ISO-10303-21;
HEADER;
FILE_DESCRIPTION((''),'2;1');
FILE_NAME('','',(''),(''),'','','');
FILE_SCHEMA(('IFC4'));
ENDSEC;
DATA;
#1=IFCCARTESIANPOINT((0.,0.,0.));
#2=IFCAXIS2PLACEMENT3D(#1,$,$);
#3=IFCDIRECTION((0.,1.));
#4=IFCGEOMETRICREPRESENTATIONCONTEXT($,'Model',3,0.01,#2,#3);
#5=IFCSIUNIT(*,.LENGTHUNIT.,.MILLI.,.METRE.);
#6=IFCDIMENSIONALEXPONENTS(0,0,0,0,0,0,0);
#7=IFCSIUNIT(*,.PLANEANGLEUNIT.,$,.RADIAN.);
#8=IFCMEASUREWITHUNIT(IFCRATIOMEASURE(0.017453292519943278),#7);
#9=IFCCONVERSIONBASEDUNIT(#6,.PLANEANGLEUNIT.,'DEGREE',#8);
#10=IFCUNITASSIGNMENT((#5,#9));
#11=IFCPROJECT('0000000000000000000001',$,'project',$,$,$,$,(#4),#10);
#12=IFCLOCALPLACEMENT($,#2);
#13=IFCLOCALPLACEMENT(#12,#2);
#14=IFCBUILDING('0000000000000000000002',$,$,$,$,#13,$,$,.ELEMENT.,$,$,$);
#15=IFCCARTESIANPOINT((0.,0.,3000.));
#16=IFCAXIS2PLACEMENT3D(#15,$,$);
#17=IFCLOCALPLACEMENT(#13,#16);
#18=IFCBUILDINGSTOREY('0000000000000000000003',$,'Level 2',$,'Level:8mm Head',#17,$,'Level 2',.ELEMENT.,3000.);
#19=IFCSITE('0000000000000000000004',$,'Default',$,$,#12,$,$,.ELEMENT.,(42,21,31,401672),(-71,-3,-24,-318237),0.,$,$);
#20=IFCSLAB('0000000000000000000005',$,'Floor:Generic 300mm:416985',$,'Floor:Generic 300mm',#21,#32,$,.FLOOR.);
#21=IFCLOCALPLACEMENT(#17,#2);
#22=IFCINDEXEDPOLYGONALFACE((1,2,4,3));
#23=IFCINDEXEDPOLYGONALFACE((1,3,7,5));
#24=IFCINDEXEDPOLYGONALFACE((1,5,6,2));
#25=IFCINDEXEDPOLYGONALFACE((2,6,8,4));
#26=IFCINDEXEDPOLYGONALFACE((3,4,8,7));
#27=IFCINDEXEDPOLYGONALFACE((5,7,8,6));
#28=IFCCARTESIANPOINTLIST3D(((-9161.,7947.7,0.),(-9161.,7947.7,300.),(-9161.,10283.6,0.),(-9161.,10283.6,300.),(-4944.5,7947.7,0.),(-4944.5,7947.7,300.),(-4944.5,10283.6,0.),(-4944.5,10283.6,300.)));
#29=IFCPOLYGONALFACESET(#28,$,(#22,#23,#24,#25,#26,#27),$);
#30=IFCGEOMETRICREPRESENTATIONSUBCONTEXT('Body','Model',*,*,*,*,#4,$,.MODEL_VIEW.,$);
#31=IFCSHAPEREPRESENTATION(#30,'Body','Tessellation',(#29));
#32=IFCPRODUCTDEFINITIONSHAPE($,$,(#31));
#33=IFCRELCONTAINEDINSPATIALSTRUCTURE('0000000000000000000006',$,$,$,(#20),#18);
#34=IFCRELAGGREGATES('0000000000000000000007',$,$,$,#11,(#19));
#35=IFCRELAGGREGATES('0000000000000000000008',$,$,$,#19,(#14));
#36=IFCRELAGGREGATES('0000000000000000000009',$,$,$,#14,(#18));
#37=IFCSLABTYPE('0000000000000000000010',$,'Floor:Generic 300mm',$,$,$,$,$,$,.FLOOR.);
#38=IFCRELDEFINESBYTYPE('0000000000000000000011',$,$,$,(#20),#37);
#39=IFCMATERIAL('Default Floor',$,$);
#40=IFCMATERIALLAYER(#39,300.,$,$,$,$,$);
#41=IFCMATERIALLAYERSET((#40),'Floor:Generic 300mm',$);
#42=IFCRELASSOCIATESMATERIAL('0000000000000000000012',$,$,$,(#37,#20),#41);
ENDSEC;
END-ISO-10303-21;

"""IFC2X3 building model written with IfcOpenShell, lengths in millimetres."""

from ifc_helpers import new_model, entity, si_unit, converted_unit, direction, frame, origin, origin_2d_with_axis, place, context, subcontext, project, spatial, rectangle, extrude, material, layer, layer_set, layer_usage, type_object, element, save


model = new_model("IFC2X3")

# Units and contexts
model_context = context("Model", 3, precision=0.01, world=origin(), true_north=direction((0.0, 1.0)))
body_context = subcontext(model_context, "Body", "Model", "MODEL_VIEW")
ifc_project = project(units=[si_unit("LENGTHUNIT", "METRE", prefix="MILLI"), converted_unit("PLANEANGLEUNIT", "DEGREE", entity("IfcRatioMeasure", 0.017453292519943278), si_unit("PLANEANGLEUNIT", "RADIAN"), dimensions=[0, 0, 0, 0, 0, 0, 0])], contexts=[model_context])

# Site, building, storey
site_placement = place(None, origin())
site = spatial("IfcSite", under=ifc_project, at=site_placement, Name="Default", CompositionType="ELEMENT", RefLatitude=(42, 21, 31, 401672), RefLongitude=(-71, -3, -24, -318237), RefElevation=0.0)
building_placement = place(site_placement, origin())
building = spatial("IfcBuilding", under=site, at=building_placement, CompositionType="ELEMENT")
storey_placement = place(building_placement, frame((0.0, 0.0, 3000.0)))
storey = spatial("IfcBuildingStorey", under=building, at=storey_placement, Name="Level 2", ObjectType="Level:8mm Head", LongName="Level 2", CompositionType="ELEMENT", Elevation=3000.0)

# Slab
ifc_material_1 = material(Name="Default Floor")
ifc_layer = layer(ifc_material_1, 300.0)
ifc_layer_set = layer_set([ifc_layer], Name="Floor:Generic 300mm")
ifc_layer_usage = layer_usage(ifc_layer_set, "AXIS3", "POSITIVE", 0.0)
slab_type = type_object("IfcSlabType", Name="Floor:Generic 300mm", PredefinedType="FLOOR", material=ifc_layer_set)
slab_placement = place(storey_placement, origin())
element("IfcSlab", 1, at=slab_placement, inside=storey, type_object=slab_type, material=ifc_layer_usage, Name="Floor:Generic 300mm:416985", ObjectType="Floor:Generic 300mm", PredefinedType="FLOOR", context=body_context, shape_type="SweptSolid", body=[
    extrude(rectangle(XDim=2335.9, YDim=4216.4, at=origin_2d_with_axis()), frame((-7052.8, 9115.7, 300.0), z_axis=(0.0, 0.0, -1.0), x_axis=(0.0, 1.0, 0.0)), (0.0, 0.0, 1.0), 300.0),
])

save(model, "model.ifc")
